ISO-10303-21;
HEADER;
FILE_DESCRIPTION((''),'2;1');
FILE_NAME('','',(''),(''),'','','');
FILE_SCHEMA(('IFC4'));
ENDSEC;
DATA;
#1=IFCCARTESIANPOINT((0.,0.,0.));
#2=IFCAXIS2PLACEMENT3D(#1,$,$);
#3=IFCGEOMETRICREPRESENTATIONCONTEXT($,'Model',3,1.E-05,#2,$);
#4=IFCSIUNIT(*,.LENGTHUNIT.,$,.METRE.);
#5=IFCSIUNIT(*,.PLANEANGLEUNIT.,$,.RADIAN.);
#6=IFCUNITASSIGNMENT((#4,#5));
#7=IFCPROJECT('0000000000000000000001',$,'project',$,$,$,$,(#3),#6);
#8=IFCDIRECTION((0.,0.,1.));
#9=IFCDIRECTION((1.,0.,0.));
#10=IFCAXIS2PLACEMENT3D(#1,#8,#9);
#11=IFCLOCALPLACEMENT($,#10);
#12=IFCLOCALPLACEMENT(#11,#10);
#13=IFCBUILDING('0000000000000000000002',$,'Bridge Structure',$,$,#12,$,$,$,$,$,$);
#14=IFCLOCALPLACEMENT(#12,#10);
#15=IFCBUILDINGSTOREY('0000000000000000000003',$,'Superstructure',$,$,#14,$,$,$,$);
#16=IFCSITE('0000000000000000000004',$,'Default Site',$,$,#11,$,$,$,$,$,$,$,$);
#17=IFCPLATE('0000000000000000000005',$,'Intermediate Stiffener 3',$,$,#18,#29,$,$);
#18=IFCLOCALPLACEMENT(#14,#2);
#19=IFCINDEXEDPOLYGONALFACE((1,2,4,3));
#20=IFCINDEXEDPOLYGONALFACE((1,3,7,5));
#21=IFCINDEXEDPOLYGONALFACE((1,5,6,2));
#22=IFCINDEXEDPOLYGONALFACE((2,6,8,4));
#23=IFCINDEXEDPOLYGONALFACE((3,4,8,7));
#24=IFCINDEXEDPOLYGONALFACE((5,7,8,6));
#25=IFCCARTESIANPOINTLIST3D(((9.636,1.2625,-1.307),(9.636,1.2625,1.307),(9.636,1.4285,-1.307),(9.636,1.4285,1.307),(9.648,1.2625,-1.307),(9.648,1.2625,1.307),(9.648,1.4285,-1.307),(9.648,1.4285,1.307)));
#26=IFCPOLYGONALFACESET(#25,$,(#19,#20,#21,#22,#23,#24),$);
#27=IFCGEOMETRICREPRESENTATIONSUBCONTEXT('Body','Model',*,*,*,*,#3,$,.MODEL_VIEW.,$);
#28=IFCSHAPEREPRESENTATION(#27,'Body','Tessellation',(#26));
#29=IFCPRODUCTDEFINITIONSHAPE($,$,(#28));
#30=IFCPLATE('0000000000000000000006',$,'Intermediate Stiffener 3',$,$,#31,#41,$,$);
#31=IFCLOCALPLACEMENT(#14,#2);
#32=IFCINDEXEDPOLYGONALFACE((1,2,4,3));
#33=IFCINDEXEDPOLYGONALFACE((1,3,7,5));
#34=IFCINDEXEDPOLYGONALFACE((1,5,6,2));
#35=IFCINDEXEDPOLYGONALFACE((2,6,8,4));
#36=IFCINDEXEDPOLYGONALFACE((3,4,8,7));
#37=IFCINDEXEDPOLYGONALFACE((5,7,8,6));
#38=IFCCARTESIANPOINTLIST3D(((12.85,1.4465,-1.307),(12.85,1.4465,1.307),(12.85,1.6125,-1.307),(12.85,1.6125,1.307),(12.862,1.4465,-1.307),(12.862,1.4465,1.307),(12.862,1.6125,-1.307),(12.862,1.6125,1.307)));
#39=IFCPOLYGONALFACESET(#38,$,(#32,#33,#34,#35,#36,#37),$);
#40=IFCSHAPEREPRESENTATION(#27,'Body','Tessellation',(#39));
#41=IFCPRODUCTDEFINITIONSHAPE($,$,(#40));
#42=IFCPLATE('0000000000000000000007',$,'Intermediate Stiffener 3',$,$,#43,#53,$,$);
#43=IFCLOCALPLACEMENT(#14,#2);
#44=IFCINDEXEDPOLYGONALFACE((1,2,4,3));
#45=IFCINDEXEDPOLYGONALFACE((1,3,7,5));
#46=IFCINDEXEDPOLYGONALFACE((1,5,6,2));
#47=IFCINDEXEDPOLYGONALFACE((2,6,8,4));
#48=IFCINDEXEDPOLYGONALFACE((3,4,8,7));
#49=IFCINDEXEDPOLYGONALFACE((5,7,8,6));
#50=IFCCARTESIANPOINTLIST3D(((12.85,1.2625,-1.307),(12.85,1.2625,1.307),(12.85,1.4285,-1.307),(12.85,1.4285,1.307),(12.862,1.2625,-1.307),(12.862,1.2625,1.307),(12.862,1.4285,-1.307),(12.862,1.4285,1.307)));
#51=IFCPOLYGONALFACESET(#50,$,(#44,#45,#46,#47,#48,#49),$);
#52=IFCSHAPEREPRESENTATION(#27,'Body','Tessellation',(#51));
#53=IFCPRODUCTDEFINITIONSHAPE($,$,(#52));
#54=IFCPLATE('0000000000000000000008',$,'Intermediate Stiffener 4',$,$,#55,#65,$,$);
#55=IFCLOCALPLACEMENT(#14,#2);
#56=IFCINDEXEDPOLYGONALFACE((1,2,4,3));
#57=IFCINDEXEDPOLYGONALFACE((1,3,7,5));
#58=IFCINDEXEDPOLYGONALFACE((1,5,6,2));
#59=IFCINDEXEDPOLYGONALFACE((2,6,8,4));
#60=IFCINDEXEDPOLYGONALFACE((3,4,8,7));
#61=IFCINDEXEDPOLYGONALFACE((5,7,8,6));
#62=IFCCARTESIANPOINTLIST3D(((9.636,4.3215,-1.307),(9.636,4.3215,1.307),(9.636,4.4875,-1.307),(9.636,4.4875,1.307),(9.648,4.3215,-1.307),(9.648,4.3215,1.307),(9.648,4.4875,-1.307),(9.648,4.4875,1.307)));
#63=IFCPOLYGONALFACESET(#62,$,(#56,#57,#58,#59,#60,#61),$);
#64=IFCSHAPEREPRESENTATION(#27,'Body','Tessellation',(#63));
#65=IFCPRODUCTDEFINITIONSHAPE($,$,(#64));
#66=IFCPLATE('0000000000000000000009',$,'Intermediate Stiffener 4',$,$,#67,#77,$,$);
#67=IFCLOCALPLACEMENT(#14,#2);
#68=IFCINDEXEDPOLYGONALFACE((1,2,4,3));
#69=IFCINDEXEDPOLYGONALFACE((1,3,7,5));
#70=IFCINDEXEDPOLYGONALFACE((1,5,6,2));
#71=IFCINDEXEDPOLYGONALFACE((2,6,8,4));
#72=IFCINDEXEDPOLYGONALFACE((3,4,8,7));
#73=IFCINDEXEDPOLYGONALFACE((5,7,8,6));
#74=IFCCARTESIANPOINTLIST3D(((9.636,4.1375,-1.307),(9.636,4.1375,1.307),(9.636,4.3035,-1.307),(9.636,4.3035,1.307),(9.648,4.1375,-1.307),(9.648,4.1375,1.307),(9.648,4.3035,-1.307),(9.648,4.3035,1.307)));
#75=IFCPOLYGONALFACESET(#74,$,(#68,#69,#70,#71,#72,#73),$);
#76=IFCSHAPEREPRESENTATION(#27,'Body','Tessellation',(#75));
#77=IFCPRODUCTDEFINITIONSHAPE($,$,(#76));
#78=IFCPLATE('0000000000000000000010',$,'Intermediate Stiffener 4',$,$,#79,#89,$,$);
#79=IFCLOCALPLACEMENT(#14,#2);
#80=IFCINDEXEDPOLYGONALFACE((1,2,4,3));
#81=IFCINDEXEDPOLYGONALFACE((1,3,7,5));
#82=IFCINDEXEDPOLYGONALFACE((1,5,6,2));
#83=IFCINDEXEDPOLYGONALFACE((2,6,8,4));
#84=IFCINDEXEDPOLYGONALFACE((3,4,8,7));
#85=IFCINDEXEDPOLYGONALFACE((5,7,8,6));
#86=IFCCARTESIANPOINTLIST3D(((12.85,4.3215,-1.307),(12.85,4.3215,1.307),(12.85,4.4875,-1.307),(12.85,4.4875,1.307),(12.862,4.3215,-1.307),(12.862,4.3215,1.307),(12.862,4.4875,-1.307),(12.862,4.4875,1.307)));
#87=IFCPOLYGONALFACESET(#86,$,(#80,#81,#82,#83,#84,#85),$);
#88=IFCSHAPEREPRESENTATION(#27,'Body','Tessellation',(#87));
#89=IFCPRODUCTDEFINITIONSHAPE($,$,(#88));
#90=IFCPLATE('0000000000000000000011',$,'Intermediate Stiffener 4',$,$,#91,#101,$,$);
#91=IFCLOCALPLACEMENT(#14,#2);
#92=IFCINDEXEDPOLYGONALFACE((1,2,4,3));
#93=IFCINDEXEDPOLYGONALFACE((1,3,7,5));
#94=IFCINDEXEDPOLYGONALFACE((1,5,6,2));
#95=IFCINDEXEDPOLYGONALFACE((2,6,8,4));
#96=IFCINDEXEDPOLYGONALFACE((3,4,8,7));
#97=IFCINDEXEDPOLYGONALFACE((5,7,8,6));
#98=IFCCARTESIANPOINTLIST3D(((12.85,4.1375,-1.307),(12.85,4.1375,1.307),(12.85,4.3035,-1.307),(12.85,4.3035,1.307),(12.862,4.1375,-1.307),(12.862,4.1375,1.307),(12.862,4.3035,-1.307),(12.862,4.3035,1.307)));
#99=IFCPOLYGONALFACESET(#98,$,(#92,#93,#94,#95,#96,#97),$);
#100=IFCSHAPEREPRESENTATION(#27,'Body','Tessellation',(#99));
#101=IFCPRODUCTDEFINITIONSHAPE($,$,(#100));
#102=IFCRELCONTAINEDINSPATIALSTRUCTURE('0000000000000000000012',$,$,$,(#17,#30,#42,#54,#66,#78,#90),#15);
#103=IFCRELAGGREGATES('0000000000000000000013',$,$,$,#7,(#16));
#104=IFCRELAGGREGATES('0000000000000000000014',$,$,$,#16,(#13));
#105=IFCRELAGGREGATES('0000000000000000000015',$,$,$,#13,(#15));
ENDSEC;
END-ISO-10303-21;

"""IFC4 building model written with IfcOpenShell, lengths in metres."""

from ifc_helpers import new_model, si_unit, frame, origin, origin_with_axes, origin_2d_with_axis, place, context, subcontext, project, spatial, rectangle, extrude, element, save


model = new_model("IFC4")

# Units and contexts
model_context = context("Model", 3, precision=1e-05, world=origin())
body_context = subcontext(model_context, "Body", "Model", "MODEL_VIEW")
ifc_project = project(units=[si_unit("LENGTHUNIT", "METRE"), si_unit("PLANEANGLEUNIT", "RADIAN")], contexts=[model_context])

# Site, building, storey
site_placement = place(None, origin_with_axes())
site = spatial("IfcSite", under=ifc_project, at=site_placement, Name="Default Site")
building_placement = place(site_placement, origin_with_axes())
building = spatial("IfcBuilding", under=site, at=building_placement, Name="Bridge Structure")
storey_placement = place(building_placement, origin_with_axes())
storey = spatial("IfcBuildingStorey", under=building, at=storey_placement, Name="Superstructure")

# Plates
for number, where, z_axis, x_axis, name in (
    (1, (9.642, 1.3455, -1.307), (0.0, 0.0, 1.0), (1.0, 0.0, 0.0), "Intermediate Stiffener 3"),
    (2, (12.856, 1.5295, -1.307), (0.0, 0.0, 1.0), (1.0, 0.0, 0.0), "Intermediate Stiffener 3"),
    (3, (12.856, 1.3455, -1.307), (0.0, 0.0, 1.0), (1.0, 0.0, 0.0), "Intermediate Stiffener 3"),
    (4, (9.642, 4.4045, -1.307), (0.0, 0.0, 1.0), (1.0, 0.0, 0.0), "Intermediate Stiffener 4"),
    (5, (9.642, 4.2205, -1.307), (0.0, 0.0, 1.0), (1.0, 0.0, 0.0), "Intermediate Stiffener 4"),
    (6, (12.856, 4.4045, -1.307), (0.0, 0.0, 1.0), (1.0, 0.0, 0.0), "Intermediate Stiffener 4"),
    (7, (12.856, 4.2205, -1.307), (0.0, 0.0, 1.0), (1.0, 0.0, 0.0), "Intermediate Stiffener 4"),
):
    element("IfcPlate", number, at=place(storey_placement, frame(where, z_axis=z_axis, x_axis=x_axis)), inside=storey, Name=name, context=body_context, shape_type="SweptSolid", body=[
        extrude(rectangle(XDim=0.012, YDim=0.166, at=origin_2d_with_axis()), origin_with_axes(), (0.0, 0.0, 1.0), 2.614),
    ])

save(model, "model.ifc")
